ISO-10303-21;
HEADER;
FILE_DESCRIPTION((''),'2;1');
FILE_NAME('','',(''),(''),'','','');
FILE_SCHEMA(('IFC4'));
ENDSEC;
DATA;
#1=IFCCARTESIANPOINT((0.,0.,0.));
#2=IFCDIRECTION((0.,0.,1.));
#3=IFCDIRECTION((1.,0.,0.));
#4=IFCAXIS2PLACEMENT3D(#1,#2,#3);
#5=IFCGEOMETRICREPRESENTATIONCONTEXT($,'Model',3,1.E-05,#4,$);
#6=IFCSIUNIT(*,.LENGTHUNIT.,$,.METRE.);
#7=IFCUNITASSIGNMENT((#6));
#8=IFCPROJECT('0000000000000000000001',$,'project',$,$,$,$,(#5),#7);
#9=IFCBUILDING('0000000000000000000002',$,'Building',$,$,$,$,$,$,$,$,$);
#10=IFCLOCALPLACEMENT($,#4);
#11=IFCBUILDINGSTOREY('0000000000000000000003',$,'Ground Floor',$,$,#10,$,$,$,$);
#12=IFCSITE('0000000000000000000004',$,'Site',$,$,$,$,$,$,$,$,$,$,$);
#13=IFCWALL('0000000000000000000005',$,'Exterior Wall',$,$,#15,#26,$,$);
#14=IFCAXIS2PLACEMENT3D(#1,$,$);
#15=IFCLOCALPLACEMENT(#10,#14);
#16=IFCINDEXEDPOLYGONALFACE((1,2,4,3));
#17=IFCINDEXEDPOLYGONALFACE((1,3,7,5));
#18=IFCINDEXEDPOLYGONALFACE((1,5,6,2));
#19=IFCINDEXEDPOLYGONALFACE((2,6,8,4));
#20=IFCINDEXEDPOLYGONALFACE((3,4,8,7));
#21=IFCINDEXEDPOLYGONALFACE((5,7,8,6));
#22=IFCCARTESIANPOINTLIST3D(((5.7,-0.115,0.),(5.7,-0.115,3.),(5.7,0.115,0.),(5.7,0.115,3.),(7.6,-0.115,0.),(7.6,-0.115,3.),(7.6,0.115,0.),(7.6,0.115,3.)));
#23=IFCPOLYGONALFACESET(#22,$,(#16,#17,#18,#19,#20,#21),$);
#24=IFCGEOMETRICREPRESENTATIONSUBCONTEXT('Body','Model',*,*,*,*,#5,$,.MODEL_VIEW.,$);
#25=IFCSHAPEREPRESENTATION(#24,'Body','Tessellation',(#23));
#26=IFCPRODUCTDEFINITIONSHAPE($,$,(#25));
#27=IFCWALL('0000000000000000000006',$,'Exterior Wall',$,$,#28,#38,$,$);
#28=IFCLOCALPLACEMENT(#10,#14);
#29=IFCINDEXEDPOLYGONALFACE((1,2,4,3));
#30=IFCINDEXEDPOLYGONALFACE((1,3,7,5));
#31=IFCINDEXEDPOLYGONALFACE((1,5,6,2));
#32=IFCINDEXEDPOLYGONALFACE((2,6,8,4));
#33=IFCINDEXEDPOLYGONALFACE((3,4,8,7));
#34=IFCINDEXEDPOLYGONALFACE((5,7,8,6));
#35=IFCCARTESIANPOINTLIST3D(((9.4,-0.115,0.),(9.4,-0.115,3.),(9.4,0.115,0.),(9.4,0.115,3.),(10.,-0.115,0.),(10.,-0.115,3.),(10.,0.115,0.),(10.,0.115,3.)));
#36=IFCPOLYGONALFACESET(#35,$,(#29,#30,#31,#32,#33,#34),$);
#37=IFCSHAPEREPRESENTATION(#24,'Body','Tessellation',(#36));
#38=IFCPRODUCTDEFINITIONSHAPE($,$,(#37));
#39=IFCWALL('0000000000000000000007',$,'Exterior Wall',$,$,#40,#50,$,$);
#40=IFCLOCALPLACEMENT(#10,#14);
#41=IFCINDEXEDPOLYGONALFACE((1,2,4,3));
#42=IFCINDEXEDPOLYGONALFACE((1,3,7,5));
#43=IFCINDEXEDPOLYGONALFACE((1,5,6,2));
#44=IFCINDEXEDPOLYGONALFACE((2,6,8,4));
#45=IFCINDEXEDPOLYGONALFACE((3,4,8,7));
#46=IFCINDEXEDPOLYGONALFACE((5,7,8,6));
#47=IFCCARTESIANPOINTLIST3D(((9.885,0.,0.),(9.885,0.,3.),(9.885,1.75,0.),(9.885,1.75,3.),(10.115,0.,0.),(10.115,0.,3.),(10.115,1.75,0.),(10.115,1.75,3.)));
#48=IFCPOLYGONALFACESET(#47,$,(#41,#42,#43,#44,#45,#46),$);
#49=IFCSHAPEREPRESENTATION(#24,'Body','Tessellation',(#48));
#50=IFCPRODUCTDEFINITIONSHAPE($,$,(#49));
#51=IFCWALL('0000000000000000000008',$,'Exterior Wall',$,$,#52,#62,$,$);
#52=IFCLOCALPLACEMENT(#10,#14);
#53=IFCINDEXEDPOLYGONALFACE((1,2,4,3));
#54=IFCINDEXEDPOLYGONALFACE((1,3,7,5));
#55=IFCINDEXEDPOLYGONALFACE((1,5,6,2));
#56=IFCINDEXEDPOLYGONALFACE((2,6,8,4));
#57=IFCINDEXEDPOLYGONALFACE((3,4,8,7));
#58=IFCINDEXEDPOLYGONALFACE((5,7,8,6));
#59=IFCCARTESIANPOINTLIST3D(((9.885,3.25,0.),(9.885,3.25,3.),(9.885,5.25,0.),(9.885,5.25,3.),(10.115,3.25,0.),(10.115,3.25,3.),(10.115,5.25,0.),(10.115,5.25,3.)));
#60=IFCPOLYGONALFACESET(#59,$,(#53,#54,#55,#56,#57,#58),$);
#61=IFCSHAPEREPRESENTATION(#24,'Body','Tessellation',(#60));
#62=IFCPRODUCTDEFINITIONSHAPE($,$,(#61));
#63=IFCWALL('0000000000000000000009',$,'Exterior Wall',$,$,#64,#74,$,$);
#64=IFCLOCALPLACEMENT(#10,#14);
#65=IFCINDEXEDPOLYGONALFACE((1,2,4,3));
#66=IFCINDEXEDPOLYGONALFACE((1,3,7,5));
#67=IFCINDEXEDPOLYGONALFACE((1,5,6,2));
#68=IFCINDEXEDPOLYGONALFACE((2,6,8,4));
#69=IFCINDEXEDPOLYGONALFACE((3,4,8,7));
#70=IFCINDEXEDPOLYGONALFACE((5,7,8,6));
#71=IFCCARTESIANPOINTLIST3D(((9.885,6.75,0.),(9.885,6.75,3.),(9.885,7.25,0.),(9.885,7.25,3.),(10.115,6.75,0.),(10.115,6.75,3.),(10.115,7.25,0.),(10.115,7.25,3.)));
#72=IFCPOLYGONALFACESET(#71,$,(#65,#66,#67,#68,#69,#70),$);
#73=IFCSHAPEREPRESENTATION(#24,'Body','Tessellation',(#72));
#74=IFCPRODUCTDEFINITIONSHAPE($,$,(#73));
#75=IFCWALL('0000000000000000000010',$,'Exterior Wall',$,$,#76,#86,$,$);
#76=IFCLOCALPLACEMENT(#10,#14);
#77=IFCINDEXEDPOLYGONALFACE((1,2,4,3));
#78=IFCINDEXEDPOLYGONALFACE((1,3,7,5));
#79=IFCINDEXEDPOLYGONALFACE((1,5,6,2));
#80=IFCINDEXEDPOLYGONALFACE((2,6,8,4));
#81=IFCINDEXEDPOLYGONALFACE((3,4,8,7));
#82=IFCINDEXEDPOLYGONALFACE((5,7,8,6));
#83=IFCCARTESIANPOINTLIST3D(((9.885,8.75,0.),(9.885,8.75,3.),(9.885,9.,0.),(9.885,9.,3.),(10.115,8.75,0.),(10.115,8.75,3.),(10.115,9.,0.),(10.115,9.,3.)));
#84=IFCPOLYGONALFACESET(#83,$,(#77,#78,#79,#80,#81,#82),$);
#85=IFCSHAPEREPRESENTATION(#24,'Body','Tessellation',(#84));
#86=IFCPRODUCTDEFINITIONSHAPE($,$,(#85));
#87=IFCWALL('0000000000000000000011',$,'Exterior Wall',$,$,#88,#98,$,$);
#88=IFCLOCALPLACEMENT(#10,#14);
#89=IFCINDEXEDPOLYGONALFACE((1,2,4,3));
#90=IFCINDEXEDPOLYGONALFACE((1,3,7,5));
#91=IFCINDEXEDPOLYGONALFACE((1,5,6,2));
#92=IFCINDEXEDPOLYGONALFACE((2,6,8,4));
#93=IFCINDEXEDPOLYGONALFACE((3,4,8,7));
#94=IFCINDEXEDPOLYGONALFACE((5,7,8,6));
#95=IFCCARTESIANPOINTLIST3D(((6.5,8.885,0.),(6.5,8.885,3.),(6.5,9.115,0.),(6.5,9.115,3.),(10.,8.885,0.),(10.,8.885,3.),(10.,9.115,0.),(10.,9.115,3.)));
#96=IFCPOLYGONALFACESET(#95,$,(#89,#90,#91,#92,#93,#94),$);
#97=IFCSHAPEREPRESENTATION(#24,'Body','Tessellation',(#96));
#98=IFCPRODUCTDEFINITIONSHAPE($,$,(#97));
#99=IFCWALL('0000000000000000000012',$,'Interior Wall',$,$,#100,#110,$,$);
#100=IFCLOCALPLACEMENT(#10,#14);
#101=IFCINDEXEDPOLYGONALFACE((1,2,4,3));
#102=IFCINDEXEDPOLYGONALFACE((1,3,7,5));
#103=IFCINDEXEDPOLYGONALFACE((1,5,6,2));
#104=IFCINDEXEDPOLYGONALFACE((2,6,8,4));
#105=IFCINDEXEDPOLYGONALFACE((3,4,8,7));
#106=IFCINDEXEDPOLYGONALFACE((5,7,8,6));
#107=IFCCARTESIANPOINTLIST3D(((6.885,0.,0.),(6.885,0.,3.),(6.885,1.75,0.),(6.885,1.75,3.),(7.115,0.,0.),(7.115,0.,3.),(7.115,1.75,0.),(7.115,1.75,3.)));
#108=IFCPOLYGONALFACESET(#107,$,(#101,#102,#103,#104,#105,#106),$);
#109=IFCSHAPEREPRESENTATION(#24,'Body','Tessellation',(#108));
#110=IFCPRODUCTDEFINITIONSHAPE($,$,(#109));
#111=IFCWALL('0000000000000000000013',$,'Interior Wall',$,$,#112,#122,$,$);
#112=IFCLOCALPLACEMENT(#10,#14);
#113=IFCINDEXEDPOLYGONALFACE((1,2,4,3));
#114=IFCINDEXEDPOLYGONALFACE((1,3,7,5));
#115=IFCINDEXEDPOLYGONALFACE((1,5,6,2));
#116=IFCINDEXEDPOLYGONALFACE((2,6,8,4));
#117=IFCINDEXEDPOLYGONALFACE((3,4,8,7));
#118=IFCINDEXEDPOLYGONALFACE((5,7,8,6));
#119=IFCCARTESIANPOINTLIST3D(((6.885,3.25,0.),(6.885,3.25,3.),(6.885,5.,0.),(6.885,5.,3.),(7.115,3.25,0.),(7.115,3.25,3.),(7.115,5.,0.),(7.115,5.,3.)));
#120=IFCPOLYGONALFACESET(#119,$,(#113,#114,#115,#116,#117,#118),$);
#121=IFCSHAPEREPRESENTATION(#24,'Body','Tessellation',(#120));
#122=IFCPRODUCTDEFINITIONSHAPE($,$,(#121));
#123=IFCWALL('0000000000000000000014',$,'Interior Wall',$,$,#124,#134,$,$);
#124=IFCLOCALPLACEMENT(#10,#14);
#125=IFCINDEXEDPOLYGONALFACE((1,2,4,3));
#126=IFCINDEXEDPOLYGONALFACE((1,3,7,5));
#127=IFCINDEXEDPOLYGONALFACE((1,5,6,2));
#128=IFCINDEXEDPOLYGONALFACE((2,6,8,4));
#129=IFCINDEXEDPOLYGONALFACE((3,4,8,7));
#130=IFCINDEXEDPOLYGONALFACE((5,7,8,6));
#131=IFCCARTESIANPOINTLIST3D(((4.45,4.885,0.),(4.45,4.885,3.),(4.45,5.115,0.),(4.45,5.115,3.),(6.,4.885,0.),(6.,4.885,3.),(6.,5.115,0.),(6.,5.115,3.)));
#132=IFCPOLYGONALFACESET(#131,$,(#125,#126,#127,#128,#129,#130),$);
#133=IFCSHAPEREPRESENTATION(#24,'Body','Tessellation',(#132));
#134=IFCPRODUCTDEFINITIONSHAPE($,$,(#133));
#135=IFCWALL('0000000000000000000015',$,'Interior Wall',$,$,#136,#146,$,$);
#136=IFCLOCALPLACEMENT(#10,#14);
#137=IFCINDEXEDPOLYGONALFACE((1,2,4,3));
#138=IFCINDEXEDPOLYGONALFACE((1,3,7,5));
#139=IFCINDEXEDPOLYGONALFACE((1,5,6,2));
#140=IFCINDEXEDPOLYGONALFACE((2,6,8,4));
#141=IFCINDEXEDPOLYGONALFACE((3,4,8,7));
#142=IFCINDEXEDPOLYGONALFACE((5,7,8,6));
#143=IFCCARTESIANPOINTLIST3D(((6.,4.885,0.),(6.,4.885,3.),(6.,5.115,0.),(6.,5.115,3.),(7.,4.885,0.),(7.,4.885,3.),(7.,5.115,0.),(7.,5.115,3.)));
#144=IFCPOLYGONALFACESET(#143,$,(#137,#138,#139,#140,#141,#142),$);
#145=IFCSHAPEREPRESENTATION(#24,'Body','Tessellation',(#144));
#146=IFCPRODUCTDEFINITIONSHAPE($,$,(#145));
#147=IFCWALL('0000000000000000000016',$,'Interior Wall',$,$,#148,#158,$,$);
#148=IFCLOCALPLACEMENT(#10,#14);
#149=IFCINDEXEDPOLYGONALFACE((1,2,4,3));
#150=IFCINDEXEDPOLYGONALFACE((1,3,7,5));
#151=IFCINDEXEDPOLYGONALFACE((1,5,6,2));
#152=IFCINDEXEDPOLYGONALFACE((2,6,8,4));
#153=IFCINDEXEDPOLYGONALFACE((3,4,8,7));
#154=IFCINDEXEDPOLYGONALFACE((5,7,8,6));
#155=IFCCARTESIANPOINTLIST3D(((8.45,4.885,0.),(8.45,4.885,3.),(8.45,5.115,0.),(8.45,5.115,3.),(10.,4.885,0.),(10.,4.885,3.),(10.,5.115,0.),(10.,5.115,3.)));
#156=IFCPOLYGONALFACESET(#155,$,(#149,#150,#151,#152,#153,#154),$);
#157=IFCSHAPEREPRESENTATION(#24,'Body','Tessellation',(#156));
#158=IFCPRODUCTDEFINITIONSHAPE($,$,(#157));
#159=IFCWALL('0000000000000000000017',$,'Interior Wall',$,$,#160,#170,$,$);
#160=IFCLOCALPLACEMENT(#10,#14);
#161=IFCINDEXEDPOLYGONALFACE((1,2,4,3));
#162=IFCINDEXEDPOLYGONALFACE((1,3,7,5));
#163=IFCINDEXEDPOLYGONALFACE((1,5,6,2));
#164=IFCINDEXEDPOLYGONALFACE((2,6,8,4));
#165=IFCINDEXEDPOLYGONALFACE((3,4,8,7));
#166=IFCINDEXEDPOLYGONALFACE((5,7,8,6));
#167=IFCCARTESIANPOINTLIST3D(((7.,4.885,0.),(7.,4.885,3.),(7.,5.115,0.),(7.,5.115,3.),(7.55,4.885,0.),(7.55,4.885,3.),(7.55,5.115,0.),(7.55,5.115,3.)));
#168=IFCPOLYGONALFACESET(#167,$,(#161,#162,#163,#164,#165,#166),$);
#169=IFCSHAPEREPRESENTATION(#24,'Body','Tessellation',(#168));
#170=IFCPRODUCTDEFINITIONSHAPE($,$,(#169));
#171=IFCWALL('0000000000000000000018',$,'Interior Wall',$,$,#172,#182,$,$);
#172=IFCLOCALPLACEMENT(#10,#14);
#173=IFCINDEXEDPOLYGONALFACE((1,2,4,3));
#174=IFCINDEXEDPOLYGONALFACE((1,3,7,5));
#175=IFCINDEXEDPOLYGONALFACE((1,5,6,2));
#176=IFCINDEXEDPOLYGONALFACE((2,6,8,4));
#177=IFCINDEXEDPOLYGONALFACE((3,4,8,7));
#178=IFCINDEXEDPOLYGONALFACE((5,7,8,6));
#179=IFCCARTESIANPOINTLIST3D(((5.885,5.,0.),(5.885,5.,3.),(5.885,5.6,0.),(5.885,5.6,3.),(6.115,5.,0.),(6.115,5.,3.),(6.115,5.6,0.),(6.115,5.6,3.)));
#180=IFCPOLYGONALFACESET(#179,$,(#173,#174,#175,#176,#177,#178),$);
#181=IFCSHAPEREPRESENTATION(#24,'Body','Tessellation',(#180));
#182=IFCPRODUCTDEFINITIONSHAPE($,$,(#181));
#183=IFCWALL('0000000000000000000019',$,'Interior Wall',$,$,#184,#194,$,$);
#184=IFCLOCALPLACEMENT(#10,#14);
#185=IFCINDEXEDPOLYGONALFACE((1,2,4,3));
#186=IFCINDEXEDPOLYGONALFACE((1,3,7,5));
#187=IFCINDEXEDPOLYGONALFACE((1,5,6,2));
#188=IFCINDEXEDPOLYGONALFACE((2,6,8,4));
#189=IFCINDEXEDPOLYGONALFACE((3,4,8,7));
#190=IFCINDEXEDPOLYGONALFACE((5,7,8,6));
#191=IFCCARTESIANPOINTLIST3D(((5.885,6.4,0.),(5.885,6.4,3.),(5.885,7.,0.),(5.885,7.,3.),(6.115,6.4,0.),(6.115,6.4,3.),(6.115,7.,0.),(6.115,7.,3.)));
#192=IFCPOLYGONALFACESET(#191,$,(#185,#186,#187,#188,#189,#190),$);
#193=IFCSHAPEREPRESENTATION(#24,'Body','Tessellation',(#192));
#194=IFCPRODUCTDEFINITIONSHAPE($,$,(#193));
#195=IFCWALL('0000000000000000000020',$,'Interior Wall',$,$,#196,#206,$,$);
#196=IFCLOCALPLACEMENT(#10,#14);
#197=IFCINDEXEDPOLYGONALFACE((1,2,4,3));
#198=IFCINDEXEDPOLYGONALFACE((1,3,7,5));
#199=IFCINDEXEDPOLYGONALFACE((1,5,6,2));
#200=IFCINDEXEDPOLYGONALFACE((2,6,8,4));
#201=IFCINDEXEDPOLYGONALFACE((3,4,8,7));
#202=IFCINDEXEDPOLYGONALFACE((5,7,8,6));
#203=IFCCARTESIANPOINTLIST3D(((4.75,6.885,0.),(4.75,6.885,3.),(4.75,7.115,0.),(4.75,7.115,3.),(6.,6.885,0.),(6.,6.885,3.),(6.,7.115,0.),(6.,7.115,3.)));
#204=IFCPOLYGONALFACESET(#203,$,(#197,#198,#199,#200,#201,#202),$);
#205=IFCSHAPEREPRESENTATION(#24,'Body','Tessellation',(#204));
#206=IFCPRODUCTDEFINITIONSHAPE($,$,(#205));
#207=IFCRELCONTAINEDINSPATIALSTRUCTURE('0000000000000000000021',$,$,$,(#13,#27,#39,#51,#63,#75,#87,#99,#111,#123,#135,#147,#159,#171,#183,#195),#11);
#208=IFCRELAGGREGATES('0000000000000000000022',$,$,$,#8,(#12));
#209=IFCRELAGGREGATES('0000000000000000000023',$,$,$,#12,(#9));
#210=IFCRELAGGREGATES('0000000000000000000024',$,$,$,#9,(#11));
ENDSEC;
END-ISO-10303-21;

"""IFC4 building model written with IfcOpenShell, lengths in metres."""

from ifc_helpers import new_model, si_unit, frame, origin_with_axes, place, context, subcontext, project, spatial, indexed_curve, outline, extrude, element, save


model = new_model("IFC4")

# Units and contexts
model_context = context("Model", 3, precision=1e-05, world=origin_with_axes())
body_context = subcontext(model_context, "Body", "Model", "MODEL_VIEW")
ifc_project = project(units=[si_unit("LENGTHUNIT", "METRE")], contexts=[model_context])

# Site, building, storey
site = spatial("IfcSite", under=ifc_project, Name="Site")
building = spatial("IfcBuilding", under=site, Name="Building")
storey_placement = place(None, origin_with_axes())
storey = spatial("IfcBuildingStorey", under=building, at=storey_placement, Name="Ground Floor")

# Walls
wall_1_placement = place(storey_placement, frame((5.7, 0.0, 0.0), z_axis=(0.0, 0.0, 1.0), x_axis=(1.0, 0.0, 0.0)))
element("IfcWall", 1, at=wall_1_placement, inside=storey, Name="Exterior Wall", context=body_context, shape_type="SweptSolid", body=[
    extrude(outline(indexed_curve([(0.0, 0.0), (0.0, 0.23), (1.9, 0.23), (1.9, 0.0), (0.0, 0.0)], self_intersect=False)), frame((0.0, -0.115, 0.0), z_axis=(0.0, 0.0, 1.0), x_axis=(1.0, 0.0, 0.0)), (0.0, 0.0, 1.0), 3.0),
])
wall_2_placement = place(storey_placement, frame((9.4, 0.0, 0.0), z_axis=(0.0, 0.0, 1.0), x_axis=(1.0, 0.0, 0.0)))
element("IfcWall", 2, at=wall_2_placement, inside=storey, Name="Exterior Wall", context=body_context, shape_type="SweptSolid", body=[
    extrude(outline(indexed_curve([(0.0, 0.0), (0.0, 0.23), (0.6, 0.23), (0.6, 0.0), (0.0, 0.0)], self_intersect=False)), frame((0.0, -0.115, 0.0), z_axis=(0.0, 0.0, 1.0), x_axis=(1.0, 0.0, 0.0)), (0.0, 0.0, 1.0), 3.0),
])
wall_3_placement = place(storey_placement, frame((10.0, 0.0, 0.0), z_axis=(0.0, 0.0, 1.0), x_axis=(0.0, 1.0, 0.0)))
element("IfcWall", 3, at=wall_3_placement, inside=storey, Name="Exterior Wall", context=body_context, shape_type="SweptSolid", body=[
    extrude(outline(indexed_curve([(0.0, 0.0), (0.0, 0.23), (1.75, 0.23), (1.75, 0.0), (0.0, 0.0)], self_intersect=False)), frame((0.0, -0.115, 0.0), z_axis=(0.0, 0.0, 1.0), x_axis=(1.0, 0.0, 0.0)), (0.0, 0.0, 1.0), 3.0),
])
wall_4_placement = place(storey_placement, frame((10.0, 3.25, 0.0), z_axis=(0.0, 0.0, 1.0), x_axis=(0.0, 1.0, 0.0)))
element("IfcWall", 4, at=wall_4_placement, inside=storey, Name="Exterior Wall", context=body_context, shape_type="SweptSolid", body=[
    extrude(outline(indexed_curve([(0.0, 0.0), (0.0, 0.23), (2.0, 0.23), (2.0, 0.0), (0.0, 0.0)], self_intersect=False)), frame((0.0, -0.115, 0.0), z_axis=(0.0, 0.0, 1.0), x_axis=(1.0, 0.0, 0.0)), (0.0, 0.0, 1.0), 3.0),
])
wall_5_placement = place(storey_placement, frame((10.0, 6.75, 0.0), z_axis=(0.0, 0.0, 1.0), x_axis=(0.0, 1.0, 0.0)))
element("IfcWall", 5, at=wall_5_placement, inside=storey, Name="Exterior Wall", context=body_context, shape_type="SweptSolid", body=[
    extrude(outline(indexed_curve([(0.0, 0.0), (0.0, 0.23), (0.5, 0.23), (0.5, 0.0), (0.0, 0.0)], self_intersect=False)), frame((0.0, -0.115, 0.0), z_axis=(0.0, 0.0, 1.0), x_axis=(1.0, 0.0, 0.0)), (0.0, 0.0, 1.0), 3.0),
])
wall_6_placement = place(storey_placement, frame((10.0, 8.75, 0.0), z_axis=(0.0, 0.0, 1.0), x_axis=(0.0, 1.0, 0.0)))
element("IfcWall", 6, at=wall_6_placement, inside=storey, Name="Exterior Wall", context=body_context, shape_type="SweptSolid", body=[
    extrude(outline(indexed_curve([(0.0, 0.0), (0.0, 0.23), (0.25, 0.23), (0.25, 0.0), (0.0, 0.0)], self_intersect=False)), frame((0.0, -0.115, 0.0), z_axis=(0.0, 0.0, 1.0), x_axis=(1.0, 0.0, 0.0)), (0.0, 0.0, 1.0), 3.0),
])
wall_7_placement = place(storey_placement, frame((10.0, 9.0, 0.0), z_axis=(0.0, 0.0, 1.0), x_axis=(-1.0, 0.0, 0.0)))
element("IfcWall", 7, at=wall_7_placement, inside=storey, Name="Exterior Wall", context=body_context, shape_type="SweptSolid", body=[
    extrude(outline(indexed_curve([(0.0, 0.0), (0.0, 0.23), (3.5, 0.23), (3.5, 0.0), (0.0, 0.0)], self_intersect=False)), frame((0.0, -0.115, 0.0), z_axis=(0.0, 0.0, 1.0), x_axis=(1.0, 0.0, 0.0)), (0.0, 0.0, 1.0), 3.0),
])
for number, where, z_axis, x_axis, name in (
    (8, (7.0, 0.0, 0.0), (0.0, 0.0, 1.0), (0.0, 1.0, 0.0), "Interior Wall"),
    (9, (7.0, 3.25, 0.0), (0.0, 0.0, 1.0), (0.0, 1.0, 0.0), "Interior Wall"),
):
    element("IfcWall", number, at=place(storey_placement, frame(where, z_axis=z_axis, x_axis=x_axis)), inside=storey, Name=name, context=body_context, shape_type="SweptSolid", body=[
        extrude(outline(indexed_curve([(0.0, 0.0), (0.0, 0.23), (1.75, 0.23), (1.75, 0.0), (0.0, 0.0)], self_intersect=False)), frame((0.0, -0.115, 0.0), z_axis=(0.0, 0.0, 1.0), x_axis=(1.0, 0.0, 0.0)), (0.0, 0.0, 1.0), 3.0),
    ])
wall_8_placement = place(storey_placement, frame((6.0, 5.0, 0.0), z_axis=(0.0, 0.0, 1.0), x_axis=(-1.0, 0.0, 0.0)))
element("IfcWall", 10, at=wall_8_placement, inside=storey, Name="Interior Wall", context=body_context, shape_type="SweptSolid", body=[
    extrude(outline(indexed_curve([(0.0, 0.0), (0.0, 0.23), (1.55, 0.23), (1.55, 0.0), (0.0, 0.0)], self_intersect=False)), frame((0.0, -0.115, 0.0), z_axis=(0.0, 0.0, 1.0), x_axis=(1.0, 0.0, 0.0)), (0.0, 0.0, 1.0), 3.0),
])
wall_9_placement = place(storey_placement, frame((7.0, 5.0, 0.0), z_axis=(0.0, 0.0, 1.0), x_axis=(-1.0, 0.0, 0.0)))
element("IfcWall", 11, at=wall_9_placement, inside=storey, Name="Interior Wall", context=body_context, shape_type="SweptSolid", body=[
    extrude(outline(indexed_curve([(0.0, 0.0), (0.0, 0.23), (1.0, 0.23), (1.0, 0.0), (0.0, 0.0)], self_intersect=False)), frame((0.0, -0.115, 0.0), z_axis=(0.0, 0.0, 1.0), x_axis=(1.0, 0.0, 0.0)), (0.0, 0.0, 1.0), 3.0),
])
wall_10_placement = place(storey_placement, frame((10.0, 5.0, 0.0), z_axis=(0.0, 0.0, 1.0), x_axis=(-1.0, 0.0, 0.0)))
element("IfcWall", 12, at=wall_10_placement, inside=storey, Name="Interior Wall", context=body_context, shape_type="SweptSolid", body=[
    extrude(outline(indexed_curve([(0.0, 0.0), (0.0, 0.23), (1.55, 0.23), (1.55, 0.0), (0.0, 0.0)], self_intersect=False)), frame((0.0, -0.115, 0.0), z_axis=(0.0, 0.0, 1.0), x_axis=(1.0, 0.0, 0.0)), (0.0, 0.0, 1.0), 3.0),
])
wall_11_placement = place(storey_placement, frame((7.55, 5.0, 0.0), z_axis=(0.0, 0.0, 1.0), x_axis=(-1.0, 0.0, 0.0)))
element("IfcWall", 13, at=wall_11_placement, inside=storey, Name="Interior Wall", context=body_context, shape_type="SweptSolid", body=[
    extrude(outline(indexed_curve([(0.0, 0.0), (0.0, 0.23), (0.55, 0.23), (0.55, 0.0), (0.0, 0.0)], self_intersect=False)), frame((0.0, -0.115, 0.0), z_axis=(0.0, 0.0, 1.0), x_axis=(1.0, 0.0, 0.0)), (0.0, 0.0, 1.0), 3.0),
])
for number, where, z_axis, x_axis, name in (
    (14, (6.0, 5.0, 0.0), (0.0, 0.0, 1.0), (0.0, 1.0, 0.0), "Interior Wall"),
    (15, (6.0, 6.4, 0.0), (0.0, 0.0, 1.0), (0.0, 1.0, 0.0), "Interior Wall"),
):
    element("IfcWall", number, at=place(storey_placement, frame(where, z_axis=z_axis, x_axis=x_axis)), inside=storey, Name=name, context=body_context, shape_type="SweptSolid", body=[
        extrude(outline(indexed_curve([(0.0, 0.0), (0.0, 0.23), (0.6, 0.23), (0.6, 0.0), (0.0, 0.0)], self_intersect=False)), frame((0.0, -0.115, 0.0), z_axis=(0.0, 0.0, 1.0), x_axis=(1.0, 0.0, 0.0)), (0.0, 0.0, 1.0), 3.0),
    ])
for number, where, z_axis, x_axis, name in (
    (16, (6.0, 7.0, 0.0), (0.0, 0.0, 1.0), (-1.0, 0.0, 0.0), "Interior Wall"),
):
    element("IfcWall", number, at=place(storey_placement, frame(where, z_axis=z_axis, x_axis=x_axis)), inside=storey, Name=name, context=body_context, shape_type="SweptSolid", body=[
        extrude(outline(indexed_curve([(0.0, 0.0), (0.0, 0.23), (1.25, 0.23), (1.25, 0.0), (0.0, 0.0)], self_intersect=False)), frame((0.0, -0.115, 0.0), z_axis=(0.0, 0.0, 1.0), x_axis=(1.0, 0.0, 0.0)), (0.0, 0.0, 1.0), 3.0),
    ])

save(model, "model.ifc")
